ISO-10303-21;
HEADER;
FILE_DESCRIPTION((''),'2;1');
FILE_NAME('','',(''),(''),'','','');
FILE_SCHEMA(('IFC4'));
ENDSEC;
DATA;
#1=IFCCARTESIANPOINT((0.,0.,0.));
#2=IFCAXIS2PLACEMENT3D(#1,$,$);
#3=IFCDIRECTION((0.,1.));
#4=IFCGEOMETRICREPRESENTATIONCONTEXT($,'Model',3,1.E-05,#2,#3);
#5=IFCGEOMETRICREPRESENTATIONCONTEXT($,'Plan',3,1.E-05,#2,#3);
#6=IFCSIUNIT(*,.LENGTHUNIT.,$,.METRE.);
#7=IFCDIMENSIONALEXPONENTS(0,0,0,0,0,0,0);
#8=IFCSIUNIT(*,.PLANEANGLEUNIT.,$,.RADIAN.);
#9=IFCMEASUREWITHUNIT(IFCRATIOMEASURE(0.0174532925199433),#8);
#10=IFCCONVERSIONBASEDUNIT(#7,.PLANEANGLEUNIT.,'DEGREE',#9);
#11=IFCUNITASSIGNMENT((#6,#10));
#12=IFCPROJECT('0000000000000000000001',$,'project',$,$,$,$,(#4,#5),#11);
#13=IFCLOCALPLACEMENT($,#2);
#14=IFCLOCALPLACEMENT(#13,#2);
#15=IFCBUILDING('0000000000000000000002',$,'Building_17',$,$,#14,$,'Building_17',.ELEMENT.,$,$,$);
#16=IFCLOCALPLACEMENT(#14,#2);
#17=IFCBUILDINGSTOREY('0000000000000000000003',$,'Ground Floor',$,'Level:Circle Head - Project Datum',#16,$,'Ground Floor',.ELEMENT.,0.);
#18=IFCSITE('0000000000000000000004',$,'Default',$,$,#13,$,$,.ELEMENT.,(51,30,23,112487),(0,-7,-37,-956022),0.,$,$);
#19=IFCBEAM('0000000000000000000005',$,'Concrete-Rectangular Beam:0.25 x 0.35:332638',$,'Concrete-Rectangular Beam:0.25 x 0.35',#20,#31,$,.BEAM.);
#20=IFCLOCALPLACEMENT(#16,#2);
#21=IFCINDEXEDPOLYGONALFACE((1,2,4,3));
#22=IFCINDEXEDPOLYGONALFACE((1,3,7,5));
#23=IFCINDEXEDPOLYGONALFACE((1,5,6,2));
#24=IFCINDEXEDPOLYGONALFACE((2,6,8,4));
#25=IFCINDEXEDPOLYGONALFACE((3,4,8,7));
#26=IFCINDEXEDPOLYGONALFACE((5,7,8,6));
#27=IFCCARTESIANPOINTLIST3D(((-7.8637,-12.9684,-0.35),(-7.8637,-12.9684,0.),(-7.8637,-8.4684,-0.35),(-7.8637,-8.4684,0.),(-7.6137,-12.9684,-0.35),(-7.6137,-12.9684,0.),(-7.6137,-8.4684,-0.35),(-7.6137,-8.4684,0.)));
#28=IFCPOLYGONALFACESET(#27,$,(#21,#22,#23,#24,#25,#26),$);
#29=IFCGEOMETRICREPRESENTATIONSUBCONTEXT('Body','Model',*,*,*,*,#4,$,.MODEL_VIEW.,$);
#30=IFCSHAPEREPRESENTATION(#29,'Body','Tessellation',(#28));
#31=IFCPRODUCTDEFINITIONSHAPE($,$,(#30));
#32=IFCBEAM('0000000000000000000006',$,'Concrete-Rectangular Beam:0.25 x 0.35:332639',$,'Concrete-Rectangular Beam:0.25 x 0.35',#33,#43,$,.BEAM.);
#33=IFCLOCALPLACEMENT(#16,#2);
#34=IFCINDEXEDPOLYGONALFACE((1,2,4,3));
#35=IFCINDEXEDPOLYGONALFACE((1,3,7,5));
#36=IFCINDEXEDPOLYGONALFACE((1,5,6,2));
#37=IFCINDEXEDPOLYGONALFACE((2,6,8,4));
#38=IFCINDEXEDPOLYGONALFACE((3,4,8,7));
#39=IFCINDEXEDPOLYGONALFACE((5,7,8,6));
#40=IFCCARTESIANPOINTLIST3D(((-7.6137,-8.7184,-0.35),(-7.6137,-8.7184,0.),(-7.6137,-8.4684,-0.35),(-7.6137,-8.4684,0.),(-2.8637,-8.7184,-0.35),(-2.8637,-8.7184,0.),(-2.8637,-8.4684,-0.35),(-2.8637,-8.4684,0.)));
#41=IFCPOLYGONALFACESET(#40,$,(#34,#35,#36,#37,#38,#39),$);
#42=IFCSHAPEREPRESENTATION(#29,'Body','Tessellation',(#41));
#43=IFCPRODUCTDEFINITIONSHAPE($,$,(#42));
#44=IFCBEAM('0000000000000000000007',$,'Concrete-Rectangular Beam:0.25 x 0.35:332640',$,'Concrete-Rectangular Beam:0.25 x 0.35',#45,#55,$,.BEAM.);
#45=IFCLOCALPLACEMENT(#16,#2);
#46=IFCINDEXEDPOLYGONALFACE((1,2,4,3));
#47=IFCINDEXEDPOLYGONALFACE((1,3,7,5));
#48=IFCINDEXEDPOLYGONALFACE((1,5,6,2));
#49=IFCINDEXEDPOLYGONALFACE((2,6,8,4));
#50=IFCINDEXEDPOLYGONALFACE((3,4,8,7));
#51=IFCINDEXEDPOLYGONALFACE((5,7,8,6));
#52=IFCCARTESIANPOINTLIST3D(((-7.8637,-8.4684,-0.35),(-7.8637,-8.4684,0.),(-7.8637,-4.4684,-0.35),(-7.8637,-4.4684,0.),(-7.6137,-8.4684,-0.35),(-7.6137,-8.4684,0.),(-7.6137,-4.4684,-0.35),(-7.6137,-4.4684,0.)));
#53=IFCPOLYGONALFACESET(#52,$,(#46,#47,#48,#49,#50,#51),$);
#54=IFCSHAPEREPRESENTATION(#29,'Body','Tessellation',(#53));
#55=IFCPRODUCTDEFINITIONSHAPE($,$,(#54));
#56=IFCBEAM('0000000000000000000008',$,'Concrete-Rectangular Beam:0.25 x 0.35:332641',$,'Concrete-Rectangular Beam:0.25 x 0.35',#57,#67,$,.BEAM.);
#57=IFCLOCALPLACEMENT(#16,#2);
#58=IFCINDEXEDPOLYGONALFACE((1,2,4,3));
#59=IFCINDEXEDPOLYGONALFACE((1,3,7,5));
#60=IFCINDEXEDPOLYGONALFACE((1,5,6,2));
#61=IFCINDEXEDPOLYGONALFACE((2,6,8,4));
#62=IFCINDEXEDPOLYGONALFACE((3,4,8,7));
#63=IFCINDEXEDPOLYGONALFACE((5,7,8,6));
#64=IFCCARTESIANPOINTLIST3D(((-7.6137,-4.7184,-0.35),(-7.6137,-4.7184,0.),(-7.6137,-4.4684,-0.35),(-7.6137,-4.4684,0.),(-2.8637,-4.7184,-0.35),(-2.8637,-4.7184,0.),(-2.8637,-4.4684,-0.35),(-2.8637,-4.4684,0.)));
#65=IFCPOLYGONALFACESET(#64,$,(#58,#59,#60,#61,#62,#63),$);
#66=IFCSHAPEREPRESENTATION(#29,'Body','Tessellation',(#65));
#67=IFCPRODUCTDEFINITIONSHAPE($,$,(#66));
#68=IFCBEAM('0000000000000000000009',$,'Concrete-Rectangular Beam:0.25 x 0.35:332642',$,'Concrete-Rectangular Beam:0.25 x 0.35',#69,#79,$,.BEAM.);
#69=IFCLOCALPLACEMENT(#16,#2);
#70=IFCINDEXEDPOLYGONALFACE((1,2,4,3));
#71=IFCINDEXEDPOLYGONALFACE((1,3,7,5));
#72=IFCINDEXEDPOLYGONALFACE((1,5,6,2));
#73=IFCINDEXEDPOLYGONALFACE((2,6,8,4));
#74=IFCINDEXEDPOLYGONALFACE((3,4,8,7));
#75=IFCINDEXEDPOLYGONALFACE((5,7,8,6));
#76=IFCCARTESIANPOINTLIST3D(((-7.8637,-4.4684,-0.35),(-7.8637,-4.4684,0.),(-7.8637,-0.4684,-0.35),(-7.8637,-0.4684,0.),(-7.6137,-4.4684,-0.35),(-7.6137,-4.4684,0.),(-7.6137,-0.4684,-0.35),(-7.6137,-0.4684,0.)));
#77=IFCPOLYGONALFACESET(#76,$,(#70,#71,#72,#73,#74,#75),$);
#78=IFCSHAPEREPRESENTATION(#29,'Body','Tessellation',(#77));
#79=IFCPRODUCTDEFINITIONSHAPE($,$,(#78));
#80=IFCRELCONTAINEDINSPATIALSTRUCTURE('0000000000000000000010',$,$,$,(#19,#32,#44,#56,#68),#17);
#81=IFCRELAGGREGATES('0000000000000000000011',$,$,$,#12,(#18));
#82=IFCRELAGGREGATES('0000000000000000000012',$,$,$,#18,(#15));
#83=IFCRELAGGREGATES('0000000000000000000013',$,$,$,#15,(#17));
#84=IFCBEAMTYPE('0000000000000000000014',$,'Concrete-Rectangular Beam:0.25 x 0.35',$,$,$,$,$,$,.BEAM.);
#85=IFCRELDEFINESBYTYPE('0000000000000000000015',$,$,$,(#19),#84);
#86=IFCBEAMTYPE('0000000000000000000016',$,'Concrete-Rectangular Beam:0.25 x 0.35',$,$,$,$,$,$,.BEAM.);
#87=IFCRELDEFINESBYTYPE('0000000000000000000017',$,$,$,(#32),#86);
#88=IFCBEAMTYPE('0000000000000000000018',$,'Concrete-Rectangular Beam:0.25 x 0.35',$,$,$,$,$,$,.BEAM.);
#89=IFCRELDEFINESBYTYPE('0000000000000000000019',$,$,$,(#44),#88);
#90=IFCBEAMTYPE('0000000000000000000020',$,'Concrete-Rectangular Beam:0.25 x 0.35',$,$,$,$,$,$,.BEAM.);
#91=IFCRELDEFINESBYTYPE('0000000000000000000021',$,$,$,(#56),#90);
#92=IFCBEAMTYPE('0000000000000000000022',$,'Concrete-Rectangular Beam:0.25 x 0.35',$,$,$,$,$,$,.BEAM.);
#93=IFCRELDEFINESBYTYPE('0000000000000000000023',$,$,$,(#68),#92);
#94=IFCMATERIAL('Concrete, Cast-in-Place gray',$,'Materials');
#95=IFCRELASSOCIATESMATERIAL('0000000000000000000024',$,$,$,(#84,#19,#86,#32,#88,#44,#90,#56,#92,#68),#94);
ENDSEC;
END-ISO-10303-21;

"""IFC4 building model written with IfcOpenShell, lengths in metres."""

from ifc_helpers import new_model, entity, si_unit, converted_unit, direction, frame, origin, place, context, subcontext, project, spatial, indexed_curve, outline, extrude, source, transform, mapped, material, type_object, type_shapes, element, save


model = new_model("IFC4")

# Units and contexts
model_context = context("Model", 3, precision=1e-05, world=origin(), true_north=direction((0.0, 1.0)))
plan_context = context("Plan", 3, precision=1e-05, world=origin(), true_north=direction((0.0, 1.0)))
body_context = subcontext(model_context, "Body", "Model", "MODEL_VIEW")
ifc_project = project(units=[si_unit("LENGTHUNIT", "METRE"), converted_unit("PLANEANGLEUNIT", "DEGREE", entity("IfcRatioMeasure", 0.0174532925199433), si_unit("PLANEANGLEUNIT", "RADIAN"), dimensions=[0, 0, 0, 0, 0, 0, 0])], contexts=[model_context, plan_context])

# Site, building, storey
site_placement = place(None, origin())
site = spatial("IfcSite", under=ifc_project, at=site_placement, Name="Default", CompositionType="ELEMENT", RefLatitude=(51, 30, 23, 112487), RefLongitude=(0, -7, -37, -956022), RefElevation=0.0)
building_placement = place(site_placement, origin())
building = spatial("IfcBuilding", under=site, at=building_placement, Name="Building_17", LongName="Building_17", CompositionType="ELEMENT")
storey_placement = place(building_placement, origin())
storey = spatial("IfcBuildingStorey", under=building, at=storey_placement, Name="Ground Floor", ObjectType="Level:Circle Head - Project Datum", LongName="Ground Floor", CompositionType="ELEMENT", Elevation=0.0)

# Beams
ifc_material_1 = material(Name="Concrete, Cast-in-Place gray", Category="Materials")
beam_type_1 = type_object("IfcBeamType", Name="Concrete-Rectangular Beam:0.25 x 0.35", PredefinedType="BEAM", material=ifc_material_1)
shared_shape_1 = source(origin(), body_context, "Body", "SweptSolid", [
    extrude(outline(indexed_curve([(-0.125, -0.175), (0.125, -0.175), (0.125, 0.175), (-0.125, 0.175), (-0.125, -0.175)], self_intersect=False)), frame((-7.7387, -12.9684, -0.175), z_axis=(0.0, 1.0, 0.0), x_axis=(-1.0, 0.0, 0.0)), (0.0, 0.0, 1.0), 4.5),
])
type_shapes(beam_type_1, [shared_shape_1])
beam_1_placement = place(storey_placement, origin())
element("IfcBeam", 1, at=beam_1_placement, inside=storey, type_object=beam_type_1, material=ifc_material_1, Name="Concrete-Rectangular Beam:0.25 x 0.35:332638", ObjectType="Concrete-Rectangular Beam:0.25 x 0.35", PredefinedType="BEAM", context=body_context, shape_type="MappedRepresentation", body=[
    mapped(shared_shape_1, transform((0.0, 0.0, 0.0), scale=1.0)),
])
beam_type_2 = type_object("IfcBeamType", Name="Concrete-Rectangular Beam:0.25 x 0.35", PredefinedType="BEAM", material=ifc_material_1)
shared_shape_2 = source(origin(), body_context, "Body", "SweptSolid", [
    extrude(outline(indexed_curve([(-0.175, -0.125), (0.175, -0.125), (0.175, 0.125), (-0.175, 0.125), (-0.175, -0.125)], self_intersect=False)), frame((-7.6137, -8.5934, -0.175), z_axis=(1.0, 0.0, 0.0), x_axis=(0.0, 0.0, -1.0)), (0.0, 0.0, 1.0), 4.75),
])
type_shapes(beam_type_2, [shared_shape_2])
beam_2_placement = place(storey_placement, origin())
element("IfcBeam", 2, at=beam_2_placement, inside=storey, type_object=beam_type_2, material=ifc_material_1, Name="Concrete-Rectangular Beam:0.25 x 0.35:332639", ObjectType="Concrete-Rectangular Beam:0.25 x 0.35", PredefinedType="BEAM", context=body_context, shape_type="MappedRepresentation", body=[
    mapped(shared_shape_2, transform((0.0, 0.0, 0.0), scale=1.0)),
])
beam_type_3 = type_object("IfcBeamType", Name="Concrete-Rectangular Beam:0.25 x 0.35", PredefinedType="BEAM", material=ifc_material_1)
shared_shape_3 = source(origin(), body_context, "Body", "SweptSolid", [
    extrude(outline(indexed_curve([(-0.125, -0.175), (0.125, -0.175), (0.125, 0.175), (-0.125, 0.175), (-0.125, -0.175)], self_intersect=False)), frame((-7.7387, -8.4684, -0.175), z_axis=(0.0, 1.0, 0.0), x_axis=(-1.0, 0.0, 0.0)), (0.0, 0.0, 1.0), 4.0),
])
type_shapes(beam_type_3, [shared_shape_3])
beam_3_placement = place(storey_placement, origin())
element("IfcBeam", 3, at=beam_3_placement, inside=storey, type_object=beam_type_3, material=ifc_material_1, Name="Concrete-Rectangular Beam:0.25 x 0.35:332640", ObjectType="Concrete-Rectangular Beam:0.25 x 0.35", PredefinedType="BEAM", context=body_context, shape_type="MappedRepresentation", body=[
    mapped(shared_shape_3, transform((0.0, 0.0, 0.0), scale=1.0)),
])
beam_type_4 = type_object("IfcBeamType", Name="Concrete-Rectangular Beam:0.25 x 0.35", PredefinedType="BEAM", material=ifc_material_1)
shared_shape_4 = source(origin(), body_context, "Body", "SweptSolid", [
    extrude(outline(indexed_curve([(-0.175, -0.125), (0.175, -0.125), (0.175, 0.125), (-0.175, 0.125), (-0.175, -0.125)], self_intersect=False)), frame((-7.6137, -4.5934, -0.175), z_axis=(1.0, 0.0, 0.0), x_axis=(0.0, 0.0, -1.0)), (0.0, 0.0, 1.0), 4.75),
])
type_shapes(beam_type_4, [shared_shape_4])
beam_4_placement = place(storey_placement, origin())
element("IfcBeam", 4, at=beam_4_placement, inside=storey, type_object=beam_type_4, material=ifc_material_1, Name="Concrete-Rectangular Beam:0.25 x 0.35:332641", ObjectType="Concrete-Rectangular Beam:0.25 x 0.35", PredefinedType="BEAM", context=body_context, shape_type="MappedRepresentation", body=[
    mapped(shared_shape_4, transform((0.0, 0.0, 0.0), scale=1.0)),
])
beam_type_5 = type_object("IfcBeamType", Name="Concrete-Rectangular Beam:0.25 x 0.35", PredefinedType="BEAM", material=ifc_material_1)
shared_shape_5 = source(origin(), body_context, "Body", "SweptSolid", [
    extrude(outline(indexed_curve([(-0.125, -0.175), (0.125, -0.175), (0.125, 0.175), (-0.125, 0.175), (-0.125, -0.175)], self_intersect=False)), frame((-7.7387, -4.4684, -0.175), z_axis=(0.0, 1.0, 0.0), x_axis=(-1.0, 0.0, 0.0)), (0.0, 0.0, 1.0), 4.0),
])
type_shapes(beam_type_5, [shared_shape_5])
beam_5_placement = place(storey_placement, origin())
element("IfcBeam", 5, at=beam_5_placement, inside=storey, type_object=beam_type_5, material=ifc_material_1, Name="Concrete-Rectangular Beam:0.25 x 0.35:332642", ObjectType="Concrete-Rectangular Beam:0.25 x 0.35", PredefinedType="BEAM", context=body_context, shape_type="MappedRepresentation", body=[
    mapped(shared_shape_5, transform((0.0, 0.0, 0.0), scale=1.0)),
])

save(model, "model.ifc")
